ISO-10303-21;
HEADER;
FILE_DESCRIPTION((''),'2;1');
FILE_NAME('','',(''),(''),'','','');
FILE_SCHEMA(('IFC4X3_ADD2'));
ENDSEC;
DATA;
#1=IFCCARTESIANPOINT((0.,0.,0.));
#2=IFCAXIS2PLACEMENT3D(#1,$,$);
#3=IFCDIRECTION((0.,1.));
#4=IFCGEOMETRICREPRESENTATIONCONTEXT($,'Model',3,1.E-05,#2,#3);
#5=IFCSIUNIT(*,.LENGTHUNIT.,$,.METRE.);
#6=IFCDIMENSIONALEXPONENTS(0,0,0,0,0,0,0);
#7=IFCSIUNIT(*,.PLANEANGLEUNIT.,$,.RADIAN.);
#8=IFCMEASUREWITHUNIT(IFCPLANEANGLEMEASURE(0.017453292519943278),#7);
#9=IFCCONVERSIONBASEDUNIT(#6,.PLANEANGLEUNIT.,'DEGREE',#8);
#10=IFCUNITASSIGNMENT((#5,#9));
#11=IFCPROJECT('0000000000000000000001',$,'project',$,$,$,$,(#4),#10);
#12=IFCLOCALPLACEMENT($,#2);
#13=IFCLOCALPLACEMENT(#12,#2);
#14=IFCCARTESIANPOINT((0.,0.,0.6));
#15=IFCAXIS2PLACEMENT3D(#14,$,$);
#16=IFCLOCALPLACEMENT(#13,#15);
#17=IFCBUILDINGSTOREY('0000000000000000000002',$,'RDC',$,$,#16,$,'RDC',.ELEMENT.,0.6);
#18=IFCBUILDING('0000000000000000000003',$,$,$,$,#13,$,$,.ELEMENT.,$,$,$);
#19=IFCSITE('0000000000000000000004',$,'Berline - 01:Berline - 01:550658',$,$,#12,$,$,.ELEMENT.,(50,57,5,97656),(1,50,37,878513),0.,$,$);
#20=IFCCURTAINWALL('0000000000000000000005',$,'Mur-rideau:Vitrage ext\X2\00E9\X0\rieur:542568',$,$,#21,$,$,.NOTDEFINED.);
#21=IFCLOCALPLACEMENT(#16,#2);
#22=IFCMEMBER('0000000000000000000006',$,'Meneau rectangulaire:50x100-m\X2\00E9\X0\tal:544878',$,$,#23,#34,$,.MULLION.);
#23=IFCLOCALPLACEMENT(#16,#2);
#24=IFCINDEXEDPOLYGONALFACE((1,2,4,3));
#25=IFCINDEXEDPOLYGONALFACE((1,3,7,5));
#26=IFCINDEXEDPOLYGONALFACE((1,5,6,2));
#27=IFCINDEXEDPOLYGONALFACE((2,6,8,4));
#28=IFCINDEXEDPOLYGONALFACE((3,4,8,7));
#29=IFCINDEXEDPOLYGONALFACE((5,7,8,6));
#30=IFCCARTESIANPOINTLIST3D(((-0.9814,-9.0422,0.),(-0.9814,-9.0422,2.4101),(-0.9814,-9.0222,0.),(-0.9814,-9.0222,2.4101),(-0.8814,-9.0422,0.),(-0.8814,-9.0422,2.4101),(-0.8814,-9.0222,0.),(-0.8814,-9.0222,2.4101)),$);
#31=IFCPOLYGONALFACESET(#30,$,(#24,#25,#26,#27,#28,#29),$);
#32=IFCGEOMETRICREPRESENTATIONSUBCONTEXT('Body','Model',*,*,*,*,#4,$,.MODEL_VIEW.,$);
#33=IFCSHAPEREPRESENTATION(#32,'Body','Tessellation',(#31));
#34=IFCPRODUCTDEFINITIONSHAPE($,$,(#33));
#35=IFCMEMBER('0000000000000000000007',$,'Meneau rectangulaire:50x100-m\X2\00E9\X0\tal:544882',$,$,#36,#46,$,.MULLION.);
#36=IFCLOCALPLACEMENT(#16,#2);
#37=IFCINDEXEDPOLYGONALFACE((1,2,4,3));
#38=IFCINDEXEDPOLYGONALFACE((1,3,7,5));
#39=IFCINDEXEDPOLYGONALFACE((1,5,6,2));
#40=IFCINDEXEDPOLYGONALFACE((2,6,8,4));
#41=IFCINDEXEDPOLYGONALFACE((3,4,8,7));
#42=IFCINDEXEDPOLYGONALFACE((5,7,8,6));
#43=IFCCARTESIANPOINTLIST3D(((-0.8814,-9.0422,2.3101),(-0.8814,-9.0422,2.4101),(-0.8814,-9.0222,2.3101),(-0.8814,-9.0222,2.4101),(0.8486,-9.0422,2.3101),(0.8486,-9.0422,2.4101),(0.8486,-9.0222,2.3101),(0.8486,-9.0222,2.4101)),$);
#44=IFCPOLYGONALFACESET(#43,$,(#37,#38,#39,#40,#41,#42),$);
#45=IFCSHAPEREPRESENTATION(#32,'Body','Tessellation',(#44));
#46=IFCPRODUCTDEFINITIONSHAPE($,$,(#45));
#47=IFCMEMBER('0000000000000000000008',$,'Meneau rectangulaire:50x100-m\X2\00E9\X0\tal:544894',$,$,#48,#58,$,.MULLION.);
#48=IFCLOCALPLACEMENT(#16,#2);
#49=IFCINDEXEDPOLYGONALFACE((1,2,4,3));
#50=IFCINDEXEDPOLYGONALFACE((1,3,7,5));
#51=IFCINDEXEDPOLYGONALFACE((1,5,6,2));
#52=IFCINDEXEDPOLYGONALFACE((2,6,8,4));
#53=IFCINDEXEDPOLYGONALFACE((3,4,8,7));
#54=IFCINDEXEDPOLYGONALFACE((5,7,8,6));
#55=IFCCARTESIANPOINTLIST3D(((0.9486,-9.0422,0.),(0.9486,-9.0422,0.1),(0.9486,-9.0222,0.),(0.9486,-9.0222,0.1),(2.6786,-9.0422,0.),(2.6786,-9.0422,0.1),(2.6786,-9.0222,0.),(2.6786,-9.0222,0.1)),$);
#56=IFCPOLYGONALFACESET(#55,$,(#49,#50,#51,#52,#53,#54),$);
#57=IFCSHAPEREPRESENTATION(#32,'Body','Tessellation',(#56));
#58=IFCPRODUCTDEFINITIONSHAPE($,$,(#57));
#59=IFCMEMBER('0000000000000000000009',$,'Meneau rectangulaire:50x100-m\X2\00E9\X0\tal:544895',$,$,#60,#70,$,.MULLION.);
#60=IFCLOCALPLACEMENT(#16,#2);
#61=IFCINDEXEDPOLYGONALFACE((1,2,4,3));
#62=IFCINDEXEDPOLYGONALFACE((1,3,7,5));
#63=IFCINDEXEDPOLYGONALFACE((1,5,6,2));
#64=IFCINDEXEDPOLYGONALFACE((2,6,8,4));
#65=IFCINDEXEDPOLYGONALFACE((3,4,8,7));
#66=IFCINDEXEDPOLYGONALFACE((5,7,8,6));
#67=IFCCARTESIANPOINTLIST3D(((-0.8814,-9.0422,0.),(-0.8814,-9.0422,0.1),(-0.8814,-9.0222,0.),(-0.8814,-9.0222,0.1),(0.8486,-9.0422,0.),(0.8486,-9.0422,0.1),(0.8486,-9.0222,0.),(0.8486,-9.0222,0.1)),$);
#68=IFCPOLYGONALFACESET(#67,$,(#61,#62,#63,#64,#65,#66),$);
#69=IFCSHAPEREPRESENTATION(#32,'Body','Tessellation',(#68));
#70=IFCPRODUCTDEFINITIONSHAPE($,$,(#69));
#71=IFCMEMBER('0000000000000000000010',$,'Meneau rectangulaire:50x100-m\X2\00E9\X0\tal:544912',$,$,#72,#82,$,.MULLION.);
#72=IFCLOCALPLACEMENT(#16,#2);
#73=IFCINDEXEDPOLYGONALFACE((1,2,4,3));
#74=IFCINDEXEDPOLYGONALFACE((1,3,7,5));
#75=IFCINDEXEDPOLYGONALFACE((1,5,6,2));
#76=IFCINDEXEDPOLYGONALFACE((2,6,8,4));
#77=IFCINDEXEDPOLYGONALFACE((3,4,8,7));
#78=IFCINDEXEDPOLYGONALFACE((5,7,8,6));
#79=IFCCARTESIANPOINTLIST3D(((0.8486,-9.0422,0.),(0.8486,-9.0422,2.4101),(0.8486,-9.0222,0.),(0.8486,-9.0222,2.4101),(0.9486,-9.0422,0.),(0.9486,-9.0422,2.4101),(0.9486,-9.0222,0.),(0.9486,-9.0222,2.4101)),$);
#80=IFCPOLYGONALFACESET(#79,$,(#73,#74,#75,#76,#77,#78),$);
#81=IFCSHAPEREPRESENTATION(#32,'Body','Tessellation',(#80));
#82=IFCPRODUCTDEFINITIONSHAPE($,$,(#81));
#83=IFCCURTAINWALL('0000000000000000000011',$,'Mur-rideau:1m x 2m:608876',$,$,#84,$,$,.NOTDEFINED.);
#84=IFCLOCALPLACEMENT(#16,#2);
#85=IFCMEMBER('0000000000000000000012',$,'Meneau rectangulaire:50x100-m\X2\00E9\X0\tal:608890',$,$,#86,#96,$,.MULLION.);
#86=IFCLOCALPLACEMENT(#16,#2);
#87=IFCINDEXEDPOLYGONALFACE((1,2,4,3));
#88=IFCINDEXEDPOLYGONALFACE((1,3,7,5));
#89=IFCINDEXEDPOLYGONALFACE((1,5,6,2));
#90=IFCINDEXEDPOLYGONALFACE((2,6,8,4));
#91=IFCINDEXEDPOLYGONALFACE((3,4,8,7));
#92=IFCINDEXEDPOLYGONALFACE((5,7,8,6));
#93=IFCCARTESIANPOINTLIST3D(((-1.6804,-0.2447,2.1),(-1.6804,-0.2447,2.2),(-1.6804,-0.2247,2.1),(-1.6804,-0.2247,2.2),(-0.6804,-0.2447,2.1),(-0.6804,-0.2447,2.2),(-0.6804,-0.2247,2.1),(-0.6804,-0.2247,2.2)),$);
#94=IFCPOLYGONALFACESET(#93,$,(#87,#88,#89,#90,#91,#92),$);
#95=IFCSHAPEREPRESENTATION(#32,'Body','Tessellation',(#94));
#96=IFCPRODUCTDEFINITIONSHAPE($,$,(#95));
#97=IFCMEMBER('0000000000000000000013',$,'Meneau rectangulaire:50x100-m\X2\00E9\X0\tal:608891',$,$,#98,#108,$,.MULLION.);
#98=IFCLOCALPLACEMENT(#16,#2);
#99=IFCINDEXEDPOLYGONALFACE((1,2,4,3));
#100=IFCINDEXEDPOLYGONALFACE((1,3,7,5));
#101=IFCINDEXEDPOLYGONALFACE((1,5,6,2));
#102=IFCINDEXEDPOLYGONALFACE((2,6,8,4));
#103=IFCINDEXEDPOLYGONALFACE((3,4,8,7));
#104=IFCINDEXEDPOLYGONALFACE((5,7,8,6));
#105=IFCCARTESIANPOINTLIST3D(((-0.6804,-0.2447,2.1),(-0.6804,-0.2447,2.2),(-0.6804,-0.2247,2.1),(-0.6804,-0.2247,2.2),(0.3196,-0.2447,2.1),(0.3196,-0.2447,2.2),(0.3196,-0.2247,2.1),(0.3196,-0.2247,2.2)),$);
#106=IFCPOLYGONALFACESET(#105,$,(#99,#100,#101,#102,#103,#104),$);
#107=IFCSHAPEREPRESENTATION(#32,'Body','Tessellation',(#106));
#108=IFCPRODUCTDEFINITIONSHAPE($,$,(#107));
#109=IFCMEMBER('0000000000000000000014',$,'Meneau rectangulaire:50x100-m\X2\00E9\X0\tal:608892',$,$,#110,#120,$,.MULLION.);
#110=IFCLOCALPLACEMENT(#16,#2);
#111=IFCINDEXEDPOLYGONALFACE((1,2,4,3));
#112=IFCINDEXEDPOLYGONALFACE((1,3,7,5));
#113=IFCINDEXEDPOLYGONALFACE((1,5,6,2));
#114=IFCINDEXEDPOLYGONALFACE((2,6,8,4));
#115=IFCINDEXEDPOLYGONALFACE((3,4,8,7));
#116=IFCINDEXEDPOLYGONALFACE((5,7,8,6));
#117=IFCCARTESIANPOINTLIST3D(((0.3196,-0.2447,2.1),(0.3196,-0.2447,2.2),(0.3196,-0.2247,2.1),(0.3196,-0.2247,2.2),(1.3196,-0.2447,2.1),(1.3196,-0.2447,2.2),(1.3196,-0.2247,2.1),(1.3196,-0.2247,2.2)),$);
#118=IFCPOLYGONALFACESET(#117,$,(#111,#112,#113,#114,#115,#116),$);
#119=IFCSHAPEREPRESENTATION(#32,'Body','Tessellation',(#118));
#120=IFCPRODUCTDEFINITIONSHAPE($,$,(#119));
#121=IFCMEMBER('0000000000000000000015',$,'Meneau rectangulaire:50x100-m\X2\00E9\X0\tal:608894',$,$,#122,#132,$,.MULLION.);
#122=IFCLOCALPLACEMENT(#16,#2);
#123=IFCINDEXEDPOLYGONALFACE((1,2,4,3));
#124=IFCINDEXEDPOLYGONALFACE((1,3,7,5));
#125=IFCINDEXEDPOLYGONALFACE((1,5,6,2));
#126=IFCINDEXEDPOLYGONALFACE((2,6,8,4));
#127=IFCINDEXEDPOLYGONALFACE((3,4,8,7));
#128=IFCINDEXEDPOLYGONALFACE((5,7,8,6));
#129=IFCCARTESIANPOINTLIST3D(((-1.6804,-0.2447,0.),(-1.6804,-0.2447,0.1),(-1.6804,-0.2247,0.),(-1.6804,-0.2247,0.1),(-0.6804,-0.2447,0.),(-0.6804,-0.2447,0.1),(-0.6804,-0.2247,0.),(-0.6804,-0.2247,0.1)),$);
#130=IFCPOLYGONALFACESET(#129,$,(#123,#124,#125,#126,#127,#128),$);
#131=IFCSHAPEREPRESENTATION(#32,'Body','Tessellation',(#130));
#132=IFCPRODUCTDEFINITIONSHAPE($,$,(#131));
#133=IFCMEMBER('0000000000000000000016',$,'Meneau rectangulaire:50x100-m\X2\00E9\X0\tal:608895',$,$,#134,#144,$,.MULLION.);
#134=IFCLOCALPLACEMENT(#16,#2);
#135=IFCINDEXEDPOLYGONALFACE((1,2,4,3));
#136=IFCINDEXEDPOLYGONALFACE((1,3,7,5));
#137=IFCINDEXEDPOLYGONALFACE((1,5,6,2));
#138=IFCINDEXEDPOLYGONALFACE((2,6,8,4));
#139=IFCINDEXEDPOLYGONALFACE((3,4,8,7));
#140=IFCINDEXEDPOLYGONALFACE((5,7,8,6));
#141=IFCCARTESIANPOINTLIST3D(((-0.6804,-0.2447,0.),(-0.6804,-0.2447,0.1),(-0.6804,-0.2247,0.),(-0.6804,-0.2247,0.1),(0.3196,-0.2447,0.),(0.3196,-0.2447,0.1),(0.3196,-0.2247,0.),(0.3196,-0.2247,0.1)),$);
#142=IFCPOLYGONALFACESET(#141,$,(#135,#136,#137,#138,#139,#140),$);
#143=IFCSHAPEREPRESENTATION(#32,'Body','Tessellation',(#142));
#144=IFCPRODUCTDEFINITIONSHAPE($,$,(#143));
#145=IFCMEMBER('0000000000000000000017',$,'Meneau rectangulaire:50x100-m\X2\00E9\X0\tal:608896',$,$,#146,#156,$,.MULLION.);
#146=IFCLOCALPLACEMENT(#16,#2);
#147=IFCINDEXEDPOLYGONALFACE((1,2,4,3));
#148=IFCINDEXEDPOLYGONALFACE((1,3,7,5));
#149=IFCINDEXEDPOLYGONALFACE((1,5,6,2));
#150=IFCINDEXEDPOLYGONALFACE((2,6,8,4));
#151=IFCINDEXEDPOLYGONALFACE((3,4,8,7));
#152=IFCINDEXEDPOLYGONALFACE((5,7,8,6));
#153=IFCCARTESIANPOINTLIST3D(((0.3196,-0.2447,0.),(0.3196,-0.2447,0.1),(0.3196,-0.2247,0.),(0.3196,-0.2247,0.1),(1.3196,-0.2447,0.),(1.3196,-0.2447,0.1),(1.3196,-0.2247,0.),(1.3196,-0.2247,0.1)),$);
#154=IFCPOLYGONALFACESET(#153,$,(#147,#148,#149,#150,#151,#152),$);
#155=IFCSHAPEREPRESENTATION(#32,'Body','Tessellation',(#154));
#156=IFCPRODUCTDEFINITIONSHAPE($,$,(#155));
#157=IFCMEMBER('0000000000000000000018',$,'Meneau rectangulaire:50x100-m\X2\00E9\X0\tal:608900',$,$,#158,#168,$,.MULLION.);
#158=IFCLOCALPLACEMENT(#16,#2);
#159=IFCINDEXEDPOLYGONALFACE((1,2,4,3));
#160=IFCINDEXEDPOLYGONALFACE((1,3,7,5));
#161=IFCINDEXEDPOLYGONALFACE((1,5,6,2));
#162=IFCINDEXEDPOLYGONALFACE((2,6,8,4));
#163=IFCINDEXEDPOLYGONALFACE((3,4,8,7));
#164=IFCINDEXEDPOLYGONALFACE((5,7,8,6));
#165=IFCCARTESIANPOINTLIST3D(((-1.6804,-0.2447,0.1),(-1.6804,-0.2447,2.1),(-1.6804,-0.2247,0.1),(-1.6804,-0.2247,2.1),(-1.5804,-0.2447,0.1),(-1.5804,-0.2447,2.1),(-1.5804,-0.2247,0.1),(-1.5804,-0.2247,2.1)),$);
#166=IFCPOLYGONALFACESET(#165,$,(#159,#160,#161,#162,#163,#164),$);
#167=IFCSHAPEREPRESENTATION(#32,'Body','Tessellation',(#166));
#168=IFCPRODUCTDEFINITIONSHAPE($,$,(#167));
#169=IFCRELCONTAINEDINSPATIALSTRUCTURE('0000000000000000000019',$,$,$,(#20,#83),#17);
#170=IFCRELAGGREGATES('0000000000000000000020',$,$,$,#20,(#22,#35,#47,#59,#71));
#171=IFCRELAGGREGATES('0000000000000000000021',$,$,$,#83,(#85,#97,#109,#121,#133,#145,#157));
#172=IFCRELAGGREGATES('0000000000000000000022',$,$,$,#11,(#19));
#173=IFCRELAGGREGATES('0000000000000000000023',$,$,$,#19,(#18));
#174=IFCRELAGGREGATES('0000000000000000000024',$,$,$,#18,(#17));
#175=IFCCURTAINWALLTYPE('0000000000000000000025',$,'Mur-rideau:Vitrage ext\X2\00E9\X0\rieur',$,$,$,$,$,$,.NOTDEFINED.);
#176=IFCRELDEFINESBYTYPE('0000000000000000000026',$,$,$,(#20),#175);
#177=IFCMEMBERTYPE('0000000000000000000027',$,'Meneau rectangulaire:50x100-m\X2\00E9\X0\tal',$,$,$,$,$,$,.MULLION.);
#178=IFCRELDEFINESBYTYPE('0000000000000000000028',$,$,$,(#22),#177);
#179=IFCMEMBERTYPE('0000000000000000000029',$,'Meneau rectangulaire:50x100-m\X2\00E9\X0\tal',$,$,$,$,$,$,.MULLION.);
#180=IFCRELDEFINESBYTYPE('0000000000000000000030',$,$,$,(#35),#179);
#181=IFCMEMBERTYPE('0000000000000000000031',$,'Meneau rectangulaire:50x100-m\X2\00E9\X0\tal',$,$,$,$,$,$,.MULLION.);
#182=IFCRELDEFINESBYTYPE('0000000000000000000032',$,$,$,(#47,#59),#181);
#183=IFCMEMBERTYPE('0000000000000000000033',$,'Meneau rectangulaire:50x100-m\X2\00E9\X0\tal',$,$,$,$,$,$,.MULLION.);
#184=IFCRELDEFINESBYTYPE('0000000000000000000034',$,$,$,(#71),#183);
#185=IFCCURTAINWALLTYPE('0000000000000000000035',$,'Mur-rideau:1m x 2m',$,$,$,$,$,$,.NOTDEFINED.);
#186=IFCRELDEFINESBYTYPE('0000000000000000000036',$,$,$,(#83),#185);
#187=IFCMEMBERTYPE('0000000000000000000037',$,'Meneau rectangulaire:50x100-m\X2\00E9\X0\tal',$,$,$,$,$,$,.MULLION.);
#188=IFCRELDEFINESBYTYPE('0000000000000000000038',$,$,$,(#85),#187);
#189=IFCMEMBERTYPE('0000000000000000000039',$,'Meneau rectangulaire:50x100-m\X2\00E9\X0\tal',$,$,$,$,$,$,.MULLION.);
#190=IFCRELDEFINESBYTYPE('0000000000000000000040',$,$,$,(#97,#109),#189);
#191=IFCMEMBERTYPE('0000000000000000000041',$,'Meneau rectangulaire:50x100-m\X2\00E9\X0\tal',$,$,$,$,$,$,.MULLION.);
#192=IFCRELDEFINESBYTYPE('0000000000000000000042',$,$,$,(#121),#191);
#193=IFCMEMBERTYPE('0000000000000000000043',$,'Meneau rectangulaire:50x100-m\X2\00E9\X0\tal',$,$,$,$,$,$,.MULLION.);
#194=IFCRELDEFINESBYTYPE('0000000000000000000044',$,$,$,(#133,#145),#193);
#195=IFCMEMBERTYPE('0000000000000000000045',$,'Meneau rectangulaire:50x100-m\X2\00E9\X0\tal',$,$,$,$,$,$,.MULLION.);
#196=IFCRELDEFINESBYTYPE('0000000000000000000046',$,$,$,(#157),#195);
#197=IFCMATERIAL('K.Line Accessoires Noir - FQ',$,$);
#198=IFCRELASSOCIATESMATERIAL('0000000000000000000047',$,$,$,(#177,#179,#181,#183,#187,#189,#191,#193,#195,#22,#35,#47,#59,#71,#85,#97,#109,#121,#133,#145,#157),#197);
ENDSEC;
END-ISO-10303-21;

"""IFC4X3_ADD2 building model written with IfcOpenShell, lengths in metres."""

from ifc_helpers import new_model, entity, si_unit, converted_unit, direction, frame, origin, origin_2d_with_axis, place, context, subcontext, project, spatial, rectangle, extrude, source, transform, mapped, material, material_profile, profile_set, profile_usage, type_object, type_shapes, element, aggregate, save


model = new_model("IFC4X3_ADD2")

# Units and contexts
model_context = context("Model", 3, precision=1e-05, world=origin(), true_north=direction((0.0, 1.0)))
body_context = subcontext(model_context, "Body", "Model", "MODEL_VIEW")
ifc_project = project(units=[si_unit("LENGTHUNIT", "METRE"), converted_unit("PLANEANGLEUNIT", "DEGREE", entity("IfcPlaneAngleMeasure", 0.017453292519943278), si_unit("PLANEANGLEUNIT", "RADIAN"), dimensions=[0, 0, 0, 0, 0, 0, 0])], contexts=[model_context])

# Site, building, storey
site_placement = place(None, origin())
site = spatial("IfcSite", under=ifc_project, at=site_placement, Name="Berline - 01:Berline - 01:550658", CompositionType="ELEMENT", RefLatitude=(50, 57, 5, 97656), RefLongitude=(1, 50, 37, 878513), RefElevation=0.0)
building_placement = place(site_placement, origin())
building = spatial("IfcBuilding", under=site, at=building_placement, CompositionType="ELEMENT")
storey_placement = place(building_placement, frame((0.0, 0.0, 0.6)))
storey = spatial("IfcBuildingStorey", under=building, at=storey_placement, Name="RDC", LongName="RDC", CompositionType="ELEMENT", Elevation=0.6)

# Curtain walls, members
curtain_wall_type_1 = type_object("IfcCurtainWallType", Name="Mur-rideau:Vitrage extérieur", PredefinedType="NOTDEFINED")
curtain_wall_1_placement = place(storey_placement, frame((0.0, 0.0, -0.6)))
curtain_wall_1 = element("IfcCurtainWall", 1, at=curtain_wall_1_placement, inside=storey, type_object=curtain_wall_type_1, Name="Mur-rideau:Vitrage extérieur:542568", PredefinedType="NOTDEFINED")
ifc_material_1 = material(Name="K.Line Accessoires Noir - FQ")
ifc_material_profile = material_profile(ifc_material_1, rectangle(XDim=0.1, YDim=0.02, at=origin_2d_with_axis()), Name="50x100-métal")
ifc_profile_set = profile_set([ifc_material_profile], Name="50x100-métal")
ifc_profile_usage = profile_usage(ifc_profile_set)
member_type_1 = type_object("IfcMemberType", Name="Meneau rectangulaire:50x100-métal", PredefinedType="MULLION", material=ifc_profile_set)
shared_shape_1 = source(origin(), body_context, "Body", "SweptSolid", [
    extrude(rectangle(XDim=0.1, YDim=0.02, at=origin_2d_with_axis()), frame((-0.05, -0.01, -2.4101)), (0.0, 0.0, 1.0), 2.4101),
])
type_shapes(member_type_1, [shared_shape_1])
member_1_placement = place(curtain_wall_1_placement, frame((-0.9814, -9.0422, 3.0101), z_axis=(0.0, 0.0, 1.0), x_axis=(-1.0, 0.0, 0.0)))
member_1 = element("IfcMember", 2, at=member_1_placement, type_object=member_type_1, material=ifc_profile_usage, Name="Meneau rectangulaire:50x100-métal:544878", PredefinedType="MULLION", context=body_context, shape_type="MappedRepresentation", body=[
    mapped(shared_shape_1, transform((0.0, 0.0, 0.0), scale=1.0)),
])
member_type_2 = type_object("IfcMemberType", Name="Meneau rectangulaire:50x100-métal", PredefinedType="MULLION", material=ifc_profile_set)
shared_shape_2 = source(origin(), body_context, "Body", "SweptSolid", [
    extrude(rectangle(XDim=0.02, YDim=0.1, at=origin_2d_with_axis()), frame((-0.05, -0.01, -1.73), z_axis=(0.0, 0.0, 1.0), x_axis=(0.0, 1.0, 0.0)), (0.0, 0.0, 1.0), 1.73),
])
type_shapes(member_type_2, [shared_shape_2])
member_2_placement = place(curtain_wall_1_placement, frame((0.8486, -9.0422, 3.0101), z_axis=(1.0, 0.0, 0.0), x_axis=(0.0, 0.0, 1.0)))
member_2 = element("IfcMember", 3, at=member_2_placement, type_object=member_type_2, material=ifc_profile_usage, Name="Meneau rectangulaire:50x100-métal:544882", PredefinedType="MULLION", context=body_context, shape_type="MappedRepresentation", body=[
    mapped(shared_shape_2, transform((0.0, 0.0, 0.0), scale=1.0)),
])
member_type_3 = type_object("IfcMemberType", Name="Meneau rectangulaire:50x100-métal", PredefinedType="MULLION", material=ifc_profile_set)
shared_shape_3 = source(origin(), body_context, "Body", "SweptSolid", [
    extrude(rectangle(XDim=0.1, YDim=0.02, at=origin_2d_with_axis()), frame((-0.05, -0.01, -1.73)), (0.0, 0.0, 1.0), 1.73),
])
type_shapes(member_type_3, [shared_shape_3])
member_3_placement = place(curtain_wall_1_placement, frame((0.9486, -9.0422, 0.6), z_axis=(-1.0, 0.0, 0.0), x_axis=(0.0, 0.0, -1.0)))
member_3 = element("IfcMember", 4, at=member_3_placement, type_object=member_type_3, material=ifc_profile_usage, Name="Meneau rectangulaire:50x100-métal:544894", PredefinedType="MULLION", context=body_context, shape_type="MappedRepresentation", body=[
    mapped(shared_shape_3, transform((0.0, 0.0, 0.0), scale=1.0)),
])
member_4_placement = place(curtain_wall_1_placement, frame((-0.8814, -9.0422, 0.6), z_axis=(-1.0, 0.0, 0.0), x_axis=(0.0, 0.0, -1.0)))
member_4 = element("IfcMember", 5, at=member_4_placement, type_object=member_type_3, material=ifc_profile_usage, Name="Meneau rectangulaire:50x100-métal:544895", PredefinedType="MULLION", context=body_context, shape_type="MappedRepresentation", body=[
    mapped(shared_shape_3, transform((0.0, 0.0, 0.0), scale=1.0)),
])
member_type_4 = type_object("IfcMemberType", Name="Meneau rectangulaire:50x100-métal", PredefinedType="MULLION", material=ifc_profile_set)
shared_shape_4 = source(origin(), body_context, "Body", "SweptSolid", [
    extrude(rectangle(XDim=0.02, YDim=0.1, at=origin_2d_with_axis()), frame((0.05, -0.01, -2.4101), z_axis=(0.0, 0.0, 1.0), x_axis=(0.0, 1.0, 0.0)), (0.0, 0.0, 1.0), 2.4101),
])
type_shapes(member_type_4, [shared_shape_4])
member_5_placement = place(curtain_wall_1_placement, frame((0.8486, -9.0422, 0.6), z_axis=(0.0, 0.0, -1.0), x_axis=(1.0, 0.0, 0.0)))
member_5 = element("IfcMember", 6, at=member_5_placement, type_object=member_type_4, material=ifc_profile_usage, Name="Meneau rectangulaire:50x100-métal:544912", PredefinedType="MULLION", context=body_context, shape_type="MappedRepresentation", body=[
    mapped(shared_shape_4, transform((0.0, 0.0, 0.0), scale=1.0)),
])
curtain_wall_type_2 = type_object("IfcCurtainWallType", Name="Mur-rideau:1m x 2m", PredefinedType="NOTDEFINED")
curtain_wall_2_placement = place(storey_placement, frame((0.0, 0.0, -0.6)))
curtain_wall_2 = element("IfcCurtainWall", 7, at=curtain_wall_2_placement, inside=storey, type_object=curtain_wall_type_2, Name="Mur-rideau:1m x 2m:608876", PredefinedType="NOTDEFINED")
member_type_5 = type_object("IfcMemberType", Name="Meneau rectangulaire:50x100-métal", PredefinedType="MULLION", material=ifc_profile_set)
shared_shape_5 = source(origin(), body_context, "Body", "SweptSolid", [
    extrude(rectangle(XDim=0.02, YDim=0.1, at=origin_2d_with_axis()), frame((-0.05, -0.01, -1.0), z_axis=(0.0, 0.0, 1.0), x_axis=(0.0, 1.0, 0.0)), (0.0, 0.0, 1.0), 1.0),
])
type_shapes(member_type_5, [shared_shape_5])
member_6_placement = place(curtain_wall_2_placement, frame((-0.6804, -0.2447, 2.8), z_axis=(1.0, 0.0, 0.0), x_axis=(0.0, 0.0, 1.0)))
member_6 = element("IfcMember", 8, at=member_6_placement, type_object=member_type_5, material=ifc_profile_usage, Name="Meneau rectangulaire:50x100-métal:608890", PredefinedType="MULLION", context=body_context, shape_type="MappedRepresentation", body=[
    mapped(shared_shape_5, transform((0.0, 0.0, 0.0), scale=1.0)),
])
member_type_6 = type_object("IfcMemberType", Name="Meneau rectangulaire:50x100-métal", PredefinedType="MULLION", material=ifc_profile_set)
shared_shape_6 = source(origin(), body_context, "Body", "SweptSolid", [
    extrude(rectangle(XDim=0.02, YDim=0.1, at=origin_2d_with_axis()), frame((-0.05, -0.01, -1.0), z_axis=(0.0, 0.0, 1.0), x_axis=(0.0, 1.0, 0.0)), (0.0, 0.0, 1.0), 1.0),
])
type_shapes(member_type_6, [shared_shape_6])
member_7_placement = place(curtain_wall_2_placement, frame((0.3196, -0.2447, 2.8), z_axis=(1.0, 0.0, 0.0), x_axis=(0.0, 0.0, 1.0)))
member_7 = element("IfcMember", 9, at=member_7_placement, type_object=member_type_6, material=ifc_profile_usage, Name="Meneau rectangulaire:50x100-métal:608891", PredefinedType="MULLION", context=body_context, shape_type="MappedRepresentation", body=[
    mapped(shared_shape_6, transform((0.0, 0.0, 0.0), scale=1.0)),
])
member_8_placement = place(curtain_wall_2_placement, frame((1.3196, -0.2447, 2.8), z_axis=(1.0, 0.0, 0.0), x_axis=(0.0, 0.0, 1.0)))
member_8 = element("IfcMember", 10, at=member_8_placement, type_object=member_type_6, material=ifc_profile_usage, Name="Meneau rectangulaire:50x100-métal:608892", PredefinedType="MULLION", context=body_context, shape_type="MappedRepresentation", body=[
    mapped(shared_shape_6, transform((0.0, 0.0, 0.0), scale=1.0)),
])
member_type_7 = type_object("IfcMemberType", Name="Meneau rectangulaire:50x100-métal", PredefinedType="MULLION", material=ifc_profile_set)
shared_shape_7 = source(origin(), body_context, "Body", "SweptSolid", [
    extrude(rectangle(XDim=0.1, YDim=0.02, at=origin_2d_with_axis()), frame((-0.05, -0.01, -1.0)), (0.0, 0.0, 1.0), 1.0),
])
type_shapes(member_type_7, [shared_shape_7])
member_9_placement = place(curtain_wall_2_placement, frame((-1.6804, -0.2447, 0.6), z_axis=(-1.0, 0.0, 0.0), x_axis=(0.0, 0.0, -1.0)))
member_9 = element("IfcMember", 11, at=member_9_placement, type_object=member_type_7, material=ifc_profile_usage, Name="Meneau rectangulaire:50x100-métal:608894", PredefinedType="MULLION", context=body_context, shape_type="MappedRepresentation", body=[
    mapped(shared_shape_7, transform((0.0, 0.0, 0.0), scale=1.0)),
])
member_type_8 = type_object("IfcMemberType", Name="Meneau rectangulaire:50x100-métal", PredefinedType="MULLION", material=ifc_profile_set)
shared_shape_8 = source(origin(), body_context, "Body", "SweptSolid", [
    extrude(rectangle(XDim=0.1, YDim=0.02, at=origin_2d_with_axis()), frame((-0.05, -0.01, -1.0)), (0.0, 0.0, 1.0), 1.0),
])
type_shapes(member_type_8, [shared_shape_8])
member_10_placement = place(curtain_wall_2_placement, frame((-0.6804, -0.2447, 0.6), z_axis=(-1.0, 0.0, 0.0), x_axis=(0.0, 0.0, -1.0)))
member_10 = element("IfcMember", 12, at=member_10_placement, type_object=member_type_8, material=ifc_profile_usage, Name="Meneau rectangulaire:50x100-métal:608895", PredefinedType="MULLION", context=body_context, shape_type="MappedRepresentation", body=[
    mapped(shared_shape_8, transform((0.0, 0.0, 0.0), scale=1.0)),
])
member_11_placement = place(curtain_wall_2_placement, frame((0.3196, -0.2447, 0.6), z_axis=(-1.0, 0.0, 0.0), x_axis=(0.0, 0.0, -1.0)))
member_11 = element("IfcMember", 13, at=member_11_placement, type_object=member_type_8, material=ifc_profile_usage, Name="Meneau rectangulaire:50x100-métal:608896", PredefinedType="MULLION", context=body_context, shape_type="MappedRepresentation", body=[
    mapped(shared_shape_8, transform((0.0, 0.0, 0.0), scale=1.0)),
])
member_type_9 = type_object("IfcMemberType", Name="Meneau rectangulaire:50x100-métal", PredefinedType="MULLION", material=ifc_profile_set)
shared_shape_9 = source(origin(), body_context, "Body", "SweptSolid", [
    extrude(rectangle(XDim=0.1, YDim=0.02, at=origin_2d_with_axis()), frame((-0.05, -0.01, -2.0)), (0.0, 0.0, 1.0), 2.0),
])
type_shapes(member_type_9, [shared_shape_9])
member_12_placement = place(curtain_wall_2_placement, frame((-1.6804, -0.2447, 2.7), z_axis=(0.0, 0.0, 1.0), x_axis=(-1.0, 0.0, 0.0)))
member_12 = element("IfcMember", 14, at=member_12_placement, type_object=member_type_9, material=ifc_profile_usage, Name="Meneau rectangulaire:50x100-métal:608900", PredefinedType="MULLION", context=body_context, shape_type="MappedRepresentation", body=[
    mapped(shared_shape_9, transform((0.0, 0.0, 0.0), scale=1.0)),
])

aggregate(curtain_wall_1, [member_1, member_2, member_3, member_4, member_5])
aggregate(curtain_wall_2, [member_6, member_7, member_8, member_9, member_10, member_11, member_12])

save(model, "model.ifc")
